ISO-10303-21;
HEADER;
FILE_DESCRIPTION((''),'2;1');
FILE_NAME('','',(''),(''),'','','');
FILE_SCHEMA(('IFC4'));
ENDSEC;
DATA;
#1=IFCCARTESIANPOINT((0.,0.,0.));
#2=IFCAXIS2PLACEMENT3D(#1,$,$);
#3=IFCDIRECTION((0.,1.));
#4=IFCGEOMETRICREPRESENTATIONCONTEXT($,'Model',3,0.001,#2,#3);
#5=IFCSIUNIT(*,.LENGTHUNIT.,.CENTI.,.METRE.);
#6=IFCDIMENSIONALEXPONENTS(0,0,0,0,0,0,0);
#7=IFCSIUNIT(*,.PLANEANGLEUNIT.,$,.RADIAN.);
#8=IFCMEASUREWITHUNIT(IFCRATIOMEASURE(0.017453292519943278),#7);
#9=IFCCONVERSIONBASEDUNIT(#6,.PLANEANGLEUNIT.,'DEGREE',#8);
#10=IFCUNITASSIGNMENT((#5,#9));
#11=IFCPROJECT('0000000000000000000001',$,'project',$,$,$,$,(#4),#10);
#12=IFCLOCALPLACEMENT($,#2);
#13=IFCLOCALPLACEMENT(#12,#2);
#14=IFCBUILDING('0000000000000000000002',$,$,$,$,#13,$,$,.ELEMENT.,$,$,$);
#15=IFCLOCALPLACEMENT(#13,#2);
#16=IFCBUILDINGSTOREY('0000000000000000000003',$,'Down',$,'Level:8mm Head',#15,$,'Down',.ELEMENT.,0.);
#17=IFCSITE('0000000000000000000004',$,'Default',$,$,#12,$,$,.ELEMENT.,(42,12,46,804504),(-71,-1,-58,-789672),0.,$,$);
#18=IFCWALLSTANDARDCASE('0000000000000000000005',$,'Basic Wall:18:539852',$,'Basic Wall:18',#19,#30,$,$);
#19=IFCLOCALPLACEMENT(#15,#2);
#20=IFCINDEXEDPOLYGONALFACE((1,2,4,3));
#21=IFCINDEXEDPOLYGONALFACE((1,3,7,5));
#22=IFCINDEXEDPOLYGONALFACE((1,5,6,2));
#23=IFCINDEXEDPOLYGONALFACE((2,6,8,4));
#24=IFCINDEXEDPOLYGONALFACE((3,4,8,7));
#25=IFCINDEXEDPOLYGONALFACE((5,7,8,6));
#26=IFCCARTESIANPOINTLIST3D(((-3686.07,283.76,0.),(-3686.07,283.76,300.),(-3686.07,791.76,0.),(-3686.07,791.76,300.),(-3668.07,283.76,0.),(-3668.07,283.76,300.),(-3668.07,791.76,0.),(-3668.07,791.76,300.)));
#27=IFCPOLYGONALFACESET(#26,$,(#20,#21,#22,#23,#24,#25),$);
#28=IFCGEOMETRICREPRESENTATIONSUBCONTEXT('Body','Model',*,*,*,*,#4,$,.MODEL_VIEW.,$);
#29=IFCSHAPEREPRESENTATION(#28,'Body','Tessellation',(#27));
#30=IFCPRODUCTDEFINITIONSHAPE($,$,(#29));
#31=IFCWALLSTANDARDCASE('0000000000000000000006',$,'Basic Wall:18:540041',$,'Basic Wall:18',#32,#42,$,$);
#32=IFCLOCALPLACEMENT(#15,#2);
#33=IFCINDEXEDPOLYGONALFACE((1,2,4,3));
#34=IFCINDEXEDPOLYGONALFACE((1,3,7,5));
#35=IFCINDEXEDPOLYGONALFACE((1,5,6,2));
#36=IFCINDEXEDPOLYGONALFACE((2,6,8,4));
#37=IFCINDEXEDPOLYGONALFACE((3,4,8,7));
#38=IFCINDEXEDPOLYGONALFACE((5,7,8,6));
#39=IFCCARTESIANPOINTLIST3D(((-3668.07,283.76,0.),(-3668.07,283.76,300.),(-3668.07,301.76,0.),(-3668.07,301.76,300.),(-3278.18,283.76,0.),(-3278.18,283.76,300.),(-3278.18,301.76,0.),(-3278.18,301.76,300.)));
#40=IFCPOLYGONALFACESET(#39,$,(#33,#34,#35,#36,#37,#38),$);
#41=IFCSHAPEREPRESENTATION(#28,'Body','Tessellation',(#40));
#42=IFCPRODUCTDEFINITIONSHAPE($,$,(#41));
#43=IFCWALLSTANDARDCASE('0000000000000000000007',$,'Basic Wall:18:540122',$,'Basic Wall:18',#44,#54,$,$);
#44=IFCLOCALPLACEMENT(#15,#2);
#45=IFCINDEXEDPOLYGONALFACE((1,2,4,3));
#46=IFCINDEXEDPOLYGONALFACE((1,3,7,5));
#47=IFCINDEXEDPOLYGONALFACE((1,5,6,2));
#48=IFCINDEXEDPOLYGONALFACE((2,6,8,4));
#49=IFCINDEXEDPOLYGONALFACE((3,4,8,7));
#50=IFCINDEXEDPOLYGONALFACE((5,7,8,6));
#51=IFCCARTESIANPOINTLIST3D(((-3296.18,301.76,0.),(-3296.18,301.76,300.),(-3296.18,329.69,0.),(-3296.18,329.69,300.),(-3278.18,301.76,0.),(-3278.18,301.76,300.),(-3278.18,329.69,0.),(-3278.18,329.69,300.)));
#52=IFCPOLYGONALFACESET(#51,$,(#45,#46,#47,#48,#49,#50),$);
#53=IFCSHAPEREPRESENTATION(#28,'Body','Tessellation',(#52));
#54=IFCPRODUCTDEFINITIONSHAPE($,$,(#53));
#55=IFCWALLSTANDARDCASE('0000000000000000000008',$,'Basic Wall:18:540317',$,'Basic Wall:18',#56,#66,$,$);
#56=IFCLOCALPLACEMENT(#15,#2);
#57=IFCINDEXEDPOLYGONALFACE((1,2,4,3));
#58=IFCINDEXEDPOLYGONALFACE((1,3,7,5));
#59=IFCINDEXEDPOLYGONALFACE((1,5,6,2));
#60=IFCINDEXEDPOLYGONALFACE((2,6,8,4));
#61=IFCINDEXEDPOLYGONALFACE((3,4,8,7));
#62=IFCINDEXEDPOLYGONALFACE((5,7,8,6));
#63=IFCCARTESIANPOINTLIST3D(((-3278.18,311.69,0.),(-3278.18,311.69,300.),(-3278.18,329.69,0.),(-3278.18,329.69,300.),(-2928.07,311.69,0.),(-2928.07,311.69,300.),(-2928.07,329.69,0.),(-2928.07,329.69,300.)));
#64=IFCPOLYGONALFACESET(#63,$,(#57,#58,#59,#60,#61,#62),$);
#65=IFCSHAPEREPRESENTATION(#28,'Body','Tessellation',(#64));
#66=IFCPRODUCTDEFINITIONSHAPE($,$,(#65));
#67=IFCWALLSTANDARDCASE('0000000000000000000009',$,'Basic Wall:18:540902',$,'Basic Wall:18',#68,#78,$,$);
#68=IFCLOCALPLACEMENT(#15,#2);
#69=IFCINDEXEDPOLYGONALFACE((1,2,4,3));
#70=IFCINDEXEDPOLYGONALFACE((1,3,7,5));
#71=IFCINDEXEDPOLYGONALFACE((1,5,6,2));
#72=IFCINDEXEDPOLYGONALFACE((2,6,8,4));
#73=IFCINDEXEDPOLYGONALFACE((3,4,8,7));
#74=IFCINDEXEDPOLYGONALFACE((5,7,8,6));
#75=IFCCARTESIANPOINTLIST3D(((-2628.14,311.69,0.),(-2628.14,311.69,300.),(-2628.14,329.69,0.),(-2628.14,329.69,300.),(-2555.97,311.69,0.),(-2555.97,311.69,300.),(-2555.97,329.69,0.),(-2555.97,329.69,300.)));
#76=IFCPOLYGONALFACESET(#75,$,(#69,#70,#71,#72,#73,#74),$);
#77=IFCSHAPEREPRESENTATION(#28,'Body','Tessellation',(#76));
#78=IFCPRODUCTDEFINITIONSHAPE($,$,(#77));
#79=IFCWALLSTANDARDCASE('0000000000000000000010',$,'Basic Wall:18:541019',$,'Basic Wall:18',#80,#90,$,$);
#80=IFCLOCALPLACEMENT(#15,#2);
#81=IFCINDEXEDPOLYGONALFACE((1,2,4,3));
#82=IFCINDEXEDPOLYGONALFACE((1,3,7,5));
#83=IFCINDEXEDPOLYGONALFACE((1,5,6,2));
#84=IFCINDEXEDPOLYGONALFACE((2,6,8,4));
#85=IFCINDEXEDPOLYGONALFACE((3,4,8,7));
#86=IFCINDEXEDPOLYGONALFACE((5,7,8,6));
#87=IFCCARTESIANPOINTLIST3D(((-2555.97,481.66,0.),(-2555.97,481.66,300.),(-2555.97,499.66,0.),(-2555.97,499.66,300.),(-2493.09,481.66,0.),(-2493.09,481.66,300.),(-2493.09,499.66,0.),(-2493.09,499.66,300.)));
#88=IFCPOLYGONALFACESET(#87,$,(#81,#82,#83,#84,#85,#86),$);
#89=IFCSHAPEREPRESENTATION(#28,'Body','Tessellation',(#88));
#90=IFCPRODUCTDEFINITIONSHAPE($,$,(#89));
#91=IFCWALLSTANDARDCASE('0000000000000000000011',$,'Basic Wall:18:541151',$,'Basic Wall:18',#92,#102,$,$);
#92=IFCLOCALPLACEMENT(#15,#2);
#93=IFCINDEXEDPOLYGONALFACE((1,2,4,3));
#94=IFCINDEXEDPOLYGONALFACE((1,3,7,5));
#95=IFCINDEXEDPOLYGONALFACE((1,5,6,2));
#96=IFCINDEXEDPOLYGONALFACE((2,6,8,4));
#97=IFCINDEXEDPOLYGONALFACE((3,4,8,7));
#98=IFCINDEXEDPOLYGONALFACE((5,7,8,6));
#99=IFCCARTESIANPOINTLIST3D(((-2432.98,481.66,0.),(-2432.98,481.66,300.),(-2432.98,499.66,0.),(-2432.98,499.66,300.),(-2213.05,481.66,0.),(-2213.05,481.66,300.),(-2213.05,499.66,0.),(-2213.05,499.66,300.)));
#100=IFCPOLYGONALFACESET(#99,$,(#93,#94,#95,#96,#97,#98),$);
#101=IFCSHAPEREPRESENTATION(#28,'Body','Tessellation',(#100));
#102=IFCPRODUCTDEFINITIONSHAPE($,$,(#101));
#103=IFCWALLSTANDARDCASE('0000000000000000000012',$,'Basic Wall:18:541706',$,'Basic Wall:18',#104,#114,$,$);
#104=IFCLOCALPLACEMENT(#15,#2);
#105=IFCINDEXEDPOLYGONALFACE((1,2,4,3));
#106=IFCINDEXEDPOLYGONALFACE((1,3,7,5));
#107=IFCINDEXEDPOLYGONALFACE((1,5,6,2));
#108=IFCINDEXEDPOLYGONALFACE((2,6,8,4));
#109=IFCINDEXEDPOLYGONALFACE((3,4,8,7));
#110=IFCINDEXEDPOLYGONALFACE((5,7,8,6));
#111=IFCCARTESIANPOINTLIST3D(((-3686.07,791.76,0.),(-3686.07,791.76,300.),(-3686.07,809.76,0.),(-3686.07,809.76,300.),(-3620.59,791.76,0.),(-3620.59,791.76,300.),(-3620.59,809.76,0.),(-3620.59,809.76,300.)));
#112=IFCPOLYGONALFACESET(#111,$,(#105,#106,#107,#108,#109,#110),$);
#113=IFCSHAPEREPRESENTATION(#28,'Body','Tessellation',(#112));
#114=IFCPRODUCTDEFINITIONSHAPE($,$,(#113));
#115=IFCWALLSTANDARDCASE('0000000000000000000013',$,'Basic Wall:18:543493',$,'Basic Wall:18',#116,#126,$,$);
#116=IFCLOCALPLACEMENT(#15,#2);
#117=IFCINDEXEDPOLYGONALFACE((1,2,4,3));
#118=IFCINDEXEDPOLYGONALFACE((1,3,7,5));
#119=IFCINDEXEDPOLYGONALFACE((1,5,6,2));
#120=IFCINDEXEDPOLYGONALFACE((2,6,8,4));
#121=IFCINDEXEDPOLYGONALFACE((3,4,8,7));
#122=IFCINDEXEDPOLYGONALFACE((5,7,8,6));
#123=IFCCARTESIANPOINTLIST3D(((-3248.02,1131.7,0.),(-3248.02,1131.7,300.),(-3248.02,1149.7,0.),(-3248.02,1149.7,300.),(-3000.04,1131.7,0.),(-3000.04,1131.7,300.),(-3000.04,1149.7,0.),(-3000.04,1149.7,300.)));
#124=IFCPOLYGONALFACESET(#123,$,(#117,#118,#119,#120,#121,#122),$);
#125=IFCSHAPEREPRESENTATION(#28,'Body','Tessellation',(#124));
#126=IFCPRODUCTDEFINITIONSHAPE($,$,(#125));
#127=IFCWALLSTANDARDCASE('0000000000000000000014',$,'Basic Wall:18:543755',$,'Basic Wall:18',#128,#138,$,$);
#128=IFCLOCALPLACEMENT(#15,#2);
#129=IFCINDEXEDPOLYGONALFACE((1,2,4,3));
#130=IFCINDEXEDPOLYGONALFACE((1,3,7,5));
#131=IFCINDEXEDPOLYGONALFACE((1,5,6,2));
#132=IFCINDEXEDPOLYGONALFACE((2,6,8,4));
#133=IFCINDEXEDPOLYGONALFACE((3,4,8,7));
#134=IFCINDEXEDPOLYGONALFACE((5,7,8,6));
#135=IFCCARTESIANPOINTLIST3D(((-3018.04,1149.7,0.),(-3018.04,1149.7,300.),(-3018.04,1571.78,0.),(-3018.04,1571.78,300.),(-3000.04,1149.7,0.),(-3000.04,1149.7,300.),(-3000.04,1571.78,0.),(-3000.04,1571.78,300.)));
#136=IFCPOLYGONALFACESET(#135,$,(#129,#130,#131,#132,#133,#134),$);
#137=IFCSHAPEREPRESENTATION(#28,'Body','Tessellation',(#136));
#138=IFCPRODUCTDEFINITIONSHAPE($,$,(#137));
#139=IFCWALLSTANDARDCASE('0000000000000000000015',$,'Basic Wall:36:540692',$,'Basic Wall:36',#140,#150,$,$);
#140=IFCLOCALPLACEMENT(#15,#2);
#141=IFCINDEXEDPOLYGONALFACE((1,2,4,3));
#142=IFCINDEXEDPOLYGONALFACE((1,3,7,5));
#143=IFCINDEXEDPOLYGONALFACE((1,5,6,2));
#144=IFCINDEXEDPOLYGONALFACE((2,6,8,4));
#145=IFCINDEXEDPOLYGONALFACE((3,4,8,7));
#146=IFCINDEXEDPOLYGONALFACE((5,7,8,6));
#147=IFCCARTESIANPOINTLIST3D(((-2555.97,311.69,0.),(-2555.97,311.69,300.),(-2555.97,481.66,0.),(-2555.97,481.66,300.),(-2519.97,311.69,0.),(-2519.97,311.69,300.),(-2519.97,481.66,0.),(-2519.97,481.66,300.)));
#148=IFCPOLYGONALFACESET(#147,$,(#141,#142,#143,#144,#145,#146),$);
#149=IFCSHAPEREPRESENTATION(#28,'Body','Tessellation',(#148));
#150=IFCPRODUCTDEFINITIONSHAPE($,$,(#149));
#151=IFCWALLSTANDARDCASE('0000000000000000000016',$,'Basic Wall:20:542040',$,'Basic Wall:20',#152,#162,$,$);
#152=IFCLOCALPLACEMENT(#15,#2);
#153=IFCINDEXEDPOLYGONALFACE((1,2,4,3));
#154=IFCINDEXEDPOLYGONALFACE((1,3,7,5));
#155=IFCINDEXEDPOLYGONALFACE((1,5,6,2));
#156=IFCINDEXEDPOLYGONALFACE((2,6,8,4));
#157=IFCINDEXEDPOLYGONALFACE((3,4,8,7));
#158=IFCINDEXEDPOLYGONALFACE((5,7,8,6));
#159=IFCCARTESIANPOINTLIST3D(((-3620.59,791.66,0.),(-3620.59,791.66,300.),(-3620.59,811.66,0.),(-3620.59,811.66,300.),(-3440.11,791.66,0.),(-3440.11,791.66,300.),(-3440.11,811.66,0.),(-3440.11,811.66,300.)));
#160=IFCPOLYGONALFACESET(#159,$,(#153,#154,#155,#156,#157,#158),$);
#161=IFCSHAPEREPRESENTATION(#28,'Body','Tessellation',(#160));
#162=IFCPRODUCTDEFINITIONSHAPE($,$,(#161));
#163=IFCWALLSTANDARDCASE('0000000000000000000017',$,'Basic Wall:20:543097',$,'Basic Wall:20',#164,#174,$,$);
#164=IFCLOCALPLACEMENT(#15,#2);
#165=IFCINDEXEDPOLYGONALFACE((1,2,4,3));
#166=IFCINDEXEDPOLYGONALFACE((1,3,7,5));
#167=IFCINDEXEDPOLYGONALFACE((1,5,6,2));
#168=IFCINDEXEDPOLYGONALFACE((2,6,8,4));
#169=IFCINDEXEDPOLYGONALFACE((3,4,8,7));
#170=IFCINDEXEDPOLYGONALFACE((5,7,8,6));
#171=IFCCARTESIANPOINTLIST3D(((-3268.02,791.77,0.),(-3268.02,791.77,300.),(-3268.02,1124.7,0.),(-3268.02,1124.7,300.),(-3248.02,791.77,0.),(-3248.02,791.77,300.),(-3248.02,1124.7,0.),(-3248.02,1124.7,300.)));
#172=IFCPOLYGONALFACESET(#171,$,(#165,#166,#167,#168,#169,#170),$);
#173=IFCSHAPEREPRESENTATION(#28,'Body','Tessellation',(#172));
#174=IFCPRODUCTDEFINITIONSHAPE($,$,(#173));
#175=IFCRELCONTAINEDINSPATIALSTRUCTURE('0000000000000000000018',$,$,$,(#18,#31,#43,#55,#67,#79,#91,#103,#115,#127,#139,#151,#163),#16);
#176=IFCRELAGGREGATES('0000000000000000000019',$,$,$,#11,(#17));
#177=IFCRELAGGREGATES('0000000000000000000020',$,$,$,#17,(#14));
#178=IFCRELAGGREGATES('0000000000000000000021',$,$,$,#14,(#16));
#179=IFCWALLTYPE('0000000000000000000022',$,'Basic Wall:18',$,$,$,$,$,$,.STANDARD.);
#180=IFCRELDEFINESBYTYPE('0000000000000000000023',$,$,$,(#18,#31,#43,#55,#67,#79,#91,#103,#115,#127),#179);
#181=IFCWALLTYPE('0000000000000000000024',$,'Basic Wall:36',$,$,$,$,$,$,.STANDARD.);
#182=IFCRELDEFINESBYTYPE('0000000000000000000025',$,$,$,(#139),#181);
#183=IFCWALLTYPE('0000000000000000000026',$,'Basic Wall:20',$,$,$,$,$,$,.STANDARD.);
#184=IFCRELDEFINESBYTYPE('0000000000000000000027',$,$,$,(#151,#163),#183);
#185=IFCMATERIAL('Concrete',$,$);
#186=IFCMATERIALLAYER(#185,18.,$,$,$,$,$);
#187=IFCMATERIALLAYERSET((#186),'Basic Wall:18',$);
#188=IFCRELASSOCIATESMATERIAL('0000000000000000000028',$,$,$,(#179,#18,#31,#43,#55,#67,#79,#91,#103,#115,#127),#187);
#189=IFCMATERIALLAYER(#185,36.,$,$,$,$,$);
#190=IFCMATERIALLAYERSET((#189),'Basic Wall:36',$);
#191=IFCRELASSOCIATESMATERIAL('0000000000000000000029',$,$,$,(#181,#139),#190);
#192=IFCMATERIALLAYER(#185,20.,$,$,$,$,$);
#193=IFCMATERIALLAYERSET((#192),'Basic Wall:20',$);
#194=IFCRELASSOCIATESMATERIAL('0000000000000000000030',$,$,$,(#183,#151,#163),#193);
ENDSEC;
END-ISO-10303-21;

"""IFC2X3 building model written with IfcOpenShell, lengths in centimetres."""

from ifc_helpers import new_model, entity, si_unit, converted_unit, direction, frame, frame_2d, origin, place, context, subcontext, project, spatial, rectangle, extrude, material, layer, layer_set, layer_usage, type_object, element, save


model = new_model("IFC2X3")

# Units and contexts
model_context = context("Model", 3, precision=0.001, world=origin(), true_north=direction((0.0, 1.0)))
body_context = subcontext(model_context, "Body", "Model", "MODEL_VIEW")
ifc_project = project(units=[si_unit("LENGTHUNIT", "METRE", prefix="CENTI"), converted_unit("PLANEANGLEUNIT", "DEGREE", entity("IfcRatioMeasure", 0.017453292519943278), si_unit("PLANEANGLEUNIT", "RADIAN"), dimensions=[0, 0, 0, 0, 0, 0, 0])], contexts=[model_context])

# Site, building, storey
site_placement = place(None, origin())
site = spatial("IfcSite", under=ifc_project, at=site_placement, Name="Default", CompositionType="ELEMENT", RefLatitude=(42, 12, 46, 804504), RefLongitude=(-71, -1, -58, -789672), RefElevation=0.0)
building_placement = place(site_placement, origin())
building = spatial("IfcBuilding", under=site, at=building_placement, CompositionType="ELEMENT")
storey_placement = place(building_placement, origin())
storey = spatial("IfcBuildingStorey", under=building, at=storey_placement, Name="Down", ObjectType="Level:8mm Head", LongName="Down", CompositionType="ELEMENT", Elevation=0.0)

# Walls
ifc_material = material(Name="Concrete")
ifc_layer_1 = layer(ifc_material, 18.0)
ifc_layer_set_1 = layer_set([ifc_layer_1], Name="Basic Wall:18")
ifc_layer_usage_1 = layer_usage(ifc_layer_set_1, "AXIS2", "POSITIVE", -9.0)
wall_type_1 = type_object("IfcWallType", Name="Basic Wall:18", PredefinedType="STANDARD", material=ifc_layer_set_1)
wall_1_placement = place(storey_placement, frame((-3677.07, 791.76, 0.0), z_axis=(0.0, 0.0, 1.0), x_axis=(0.0, -1.0, 0.0)))
element("IfcWallStandardCase", 1, at=wall_1_placement, inside=storey, type_object=wall_type_1, material=ifc_layer_usage_1, Name="Basic Wall:18:539852", ObjectType="Basic Wall:18", context=body_context, shape_type="SweptSolid", body=[
    extrude(rectangle(XDim=508.0, YDim=18.0, at=frame_2d((254.0, 0.0), x_axis=(-1.0, 0.0))), origin(), (0.0, 0.0, 1.0), 300.0),
])
ifc_layer_usage_2 = layer_usage(ifc_layer_set_1, "AXIS2", "POSITIVE", -9.0)
wall_2_placement = place(storey_placement, frame((-3668.07, 292.76, 0.0)))
element("IfcWallStandardCase", 2, at=wall_2_placement, inside=storey, type_object=wall_type_1, material=ifc_layer_usage_2, Name="Basic Wall:18:540041", ObjectType="Basic Wall:18", context=body_context, shape_type="SweptSolid", body=[
    extrude(rectangle(XDim=389.89, YDim=18.0, at=frame_2d((194.95, 0.0), x_axis=(-1.0, 0.0))), origin(), (0.0, 0.0, 1.0), 300.0),
])
ifc_layer_usage_3 = layer_usage(ifc_layer_set_1, "AXIS2", "POSITIVE", -9.0)
wall_3_placement = place(storey_placement, frame((-3287.18, 301.76, 0.0), z_axis=(0.0, 0.0, 1.0), x_axis=(0.0, 1.0, 0.0)))
element("IfcWallStandardCase", 3, at=wall_3_placement, inside=storey, type_object=wall_type_1, material=ifc_layer_usage_3, Name="Basic Wall:18:540122", ObjectType="Basic Wall:18", context=body_context, shape_type="SweptSolid", body=[
    extrude(rectangle(XDim=27.93, YDim=18.0, at=frame_2d((13.97, 0.0), x_axis=(-1.0, 0.0))), origin(), (0.0, 0.0, 1.0), 300.0),
])
ifc_layer_usage_4 = layer_usage(ifc_layer_set_1, "AXIS2", "NEGATIVE", 9.0)
wall_4_placement = place(storey_placement, frame((-3278.18, 320.69, 0.0)))
element("IfcWallStandardCase", 4, at=wall_4_placement, inside=storey, type_object=wall_type_1, material=ifc_layer_usage_4, Name="Basic Wall:18:540317", ObjectType="Basic Wall:18", context=body_context, shape_type="SweptSolid", body=[
    extrude(rectangle(XDim=350.1, YDim=18.0, at=frame_2d((175.05, 0.0), x_axis=(-1.0, 0.0))), origin(), (0.0, 0.0, 1.0), 300.0),
])
ifc_layer_usage_5 = layer_usage(ifc_layer_set_1, "AXIS2", "NEGATIVE", 9.0)
wall_5_placement = place(storey_placement, frame((-2628.14, 320.69, 0.0)))
element("IfcWallStandardCase", 5, at=wall_5_placement, inside=storey, type_object=wall_type_1, material=ifc_layer_usage_5, Name="Basic Wall:18:540902", ObjectType="Basic Wall:18", context=body_context, shape_type="SweptSolid", body=[
    extrude(rectangle(XDim=72.16, YDim=18.0, at=frame_2d((36.08, 0.0), x_axis=(-1.0, 0.0))), origin(), (0.0, 0.0, 1.0), 300.0),
])
ifc_layer_usage_6 = layer_usage(ifc_layer_set_1, "AXIS2", "NEGATIVE", 9.0)
wall_6_placement = place(storey_placement, frame((-2555.97, 490.66, 0.0)))
element("IfcWallStandardCase", 6, at=wall_6_placement, inside=storey, type_object=wall_type_1, material=ifc_layer_usage_6, Name="Basic Wall:18:541019", ObjectType="Basic Wall:18", context=body_context, shape_type="SweptSolid", body=[
    extrude(rectangle(XDim=62.88, YDim=18.0, at=frame_2d((31.44, 0.0), x_axis=(-1.0, 0.0))), origin(), (0.0, 0.0, 1.0), 300.0),
])
ifc_layer_usage_7 = layer_usage(ifc_layer_set_1, "AXIS2", "NEGATIVE", 9.0)
wall_7_placement = place(storey_placement, frame((-2432.98, 490.66, 0.0)))
element("IfcWallStandardCase", 7, at=wall_7_placement, inside=storey, type_object=wall_type_1, material=ifc_layer_usage_7, Name="Basic Wall:18:541151", ObjectType="Basic Wall:18", context=body_context, shape_type="SweptSolid", body=[
    extrude(rectangle(XDim=219.93, YDim=18.0, at=frame_2d((109.96, 0.0), x_axis=(-1.0, 0.0))), origin(), (0.0, 0.0, 1.0), 300.0),
])
ifc_layer_usage_8 = layer_usage(ifc_layer_set_1, "AXIS2", "NEGATIVE", 9.0)
wall_8_placement = place(storey_placement, frame((-3686.07, 800.76, 0.0)))
element("IfcWallStandardCase", 8, at=wall_8_placement, inside=storey, type_object=wall_type_1, material=ifc_layer_usage_8, Name="Basic Wall:18:541706", ObjectType="Basic Wall:18", context=body_context, shape_type="SweptSolid", body=[
    extrude(rectangle(XDim=65.48, YDim=18.0, at=frame_2d((32.74, 0.0), x_axis=(-1.0, 0.0))), origin(), (0.0, 0.0, 1.0), 300.0),
])
ifc_layer_usage_9 = layer_usage(ifc_layer_set_1, "AXIS2", "NEGATIVE", 9.0)
wall_9_placement = place(storey_placement, frame((-3248.02, 1140.7, 0.0)))
element("IfcWallStandardCase", 9, at=wall_9_placement, inside=storey, type_object=wall_type_1, material=ifc_layer_usage_9, Name="Basic Wall:18:543493", ObjectType="Basic Wall:18", context=body_context, shape_type="SweptSolid", body=[
    extrude(rectangle(XDim=247.98, YDim=18.0, at=frame_2d((123.99, 0.0), x_axis=(-1.0, 0.0))), origin(), (0.0, 0.0, 1.0), 300.0),
])
ifc_layer_usage_10 = layer_usage(ifc_layer_set_1, "AXIS2", "POSITIVE", -9.0)
wall_10_placement = place(storey_placement, frame((-3009.04, 1149.7, 0.0), z_axis=(0.0, 0.0, 1.0), x_axis=(0.0, 1.0, 0.0)))
element("IfcWallStandardCase", 10, at=wall_10_placement, inside=storey, type_object=wall_type_1, material=ifc_layer_usage_10, Name="Basic Wall:18:543755", ObjectType="Basic Wall:18", context=body_context, shape_type="SweptSolid", body=[
    extrude(rectangle(XDim=422.07, YDim=18.0, at=frame_2d((211.04, 0.0), x_axis=(-1.0, 0.0))), origin(), (0.0, 0.0, 1.0), 300.0),
])
ifc_layer_2 = layer(ifc_material, 36.0)
ifc_layer_set_2 = layer_set([ifc_layer_2], Name="Basic Wall:36")
ifc_layer_usage_11 = layer_usage(ifc_layer_set_2, "AXIS2", "POSITIVE", -18.0)
wall_type_2 = type_object("IfcWallType", Name="Basic Wall:36", PredefinedType="STANDARD", material=ifc_layer_set_2)
wall_11_placement = place(storey_placement, frame((-2537.97, 311.69, 0.0), z_axis=(0.0, 0.0, 1.0), x_axis=(0.0, 1.0, 0.0)))
element("IfcWallStandardCase", 11, at=wall_11_placement, inside=storey, type_object=wall_type_2, material=ifc_layer_usage_11, Name="Basic Wall:36:540692", ObjectType="Basic Wall:36", context=body_context, shape_type="SweptSolid", body=[
    extrude(rectangle(XDim=169.97, YDim=36.0, at=frame_2d((84.99, 0.0), x_axis=(-1.0, 0.0))), origin(), (0.0, 0.0, 1.0), 300.0),
])
ifc_layer_3 = layer(ifc_material, 20.0)
ifc_layer_set_3 = layer_set([ifc_layer_3], Name="Basic Wall:20")
ifc_layer_usage_12 = layer_usage(ifc_layer_set_3, "AXIS2", "POSITIVE", -10.0)
wall_type_3 = type_object("IfcWallType", Name="Basic Wall:20", PredefinedType="STANDARD", material=ifc_layer_set_3)
wall_12_placement = place(storey_placement, frame((-3440.11, 801.66, 0.0), z_axis=(0.0, 0.0, 1.0), x_axis=(-1.0, 0.0, 0.0)))
element("IfcWallStandardCase", 12, at=wall_12_placement, inside=storey, type_object=wall_type_3, material=ifc_layer_usage_12, Name="Basic Wall:20:542040", ObjectType="Basic Wall:20", context=body_context, shape_type="SweptSolid", body=[
    extrude(rectangle(XDim=180.49, YDim=20.0, at=frame_2d((90.24, 0.0), x_axis=(-1.0, 0.0))), origin(), (0.0, 0.0, 1.0), 300.0),
])
ifc_layer_usage_13 = layer_usage(ifc_layer_set_3, "AXIS2", "POSITIVE", -10.0)
wall_13_placement = place(storey_placement, frame((-3258.02, 1124.7, 0.0), z_axis=(0.0, 0.0, 1.0), x_axis=(0.0, -1.0, 0.0)))
element("IfcWallStandardCase", 13, at=wall_13_placement, inside=storey, type_object=wall_type_3, material=ifc_layer_usage_13, Name="Basic Wall:20:543097", ObjectType="Basic Wall:20", context=body_context, shape_type="SweptSolid", body=[
    extrude(rectangle(XDim=332.94, YDim=20.0, at=frame_2d((166.47, 0.0), x_axis=(-1.0, 0.0))), origin(), (0.0, 0.0, 1.0), 300.0),
])

save(model, "model.ifc")
